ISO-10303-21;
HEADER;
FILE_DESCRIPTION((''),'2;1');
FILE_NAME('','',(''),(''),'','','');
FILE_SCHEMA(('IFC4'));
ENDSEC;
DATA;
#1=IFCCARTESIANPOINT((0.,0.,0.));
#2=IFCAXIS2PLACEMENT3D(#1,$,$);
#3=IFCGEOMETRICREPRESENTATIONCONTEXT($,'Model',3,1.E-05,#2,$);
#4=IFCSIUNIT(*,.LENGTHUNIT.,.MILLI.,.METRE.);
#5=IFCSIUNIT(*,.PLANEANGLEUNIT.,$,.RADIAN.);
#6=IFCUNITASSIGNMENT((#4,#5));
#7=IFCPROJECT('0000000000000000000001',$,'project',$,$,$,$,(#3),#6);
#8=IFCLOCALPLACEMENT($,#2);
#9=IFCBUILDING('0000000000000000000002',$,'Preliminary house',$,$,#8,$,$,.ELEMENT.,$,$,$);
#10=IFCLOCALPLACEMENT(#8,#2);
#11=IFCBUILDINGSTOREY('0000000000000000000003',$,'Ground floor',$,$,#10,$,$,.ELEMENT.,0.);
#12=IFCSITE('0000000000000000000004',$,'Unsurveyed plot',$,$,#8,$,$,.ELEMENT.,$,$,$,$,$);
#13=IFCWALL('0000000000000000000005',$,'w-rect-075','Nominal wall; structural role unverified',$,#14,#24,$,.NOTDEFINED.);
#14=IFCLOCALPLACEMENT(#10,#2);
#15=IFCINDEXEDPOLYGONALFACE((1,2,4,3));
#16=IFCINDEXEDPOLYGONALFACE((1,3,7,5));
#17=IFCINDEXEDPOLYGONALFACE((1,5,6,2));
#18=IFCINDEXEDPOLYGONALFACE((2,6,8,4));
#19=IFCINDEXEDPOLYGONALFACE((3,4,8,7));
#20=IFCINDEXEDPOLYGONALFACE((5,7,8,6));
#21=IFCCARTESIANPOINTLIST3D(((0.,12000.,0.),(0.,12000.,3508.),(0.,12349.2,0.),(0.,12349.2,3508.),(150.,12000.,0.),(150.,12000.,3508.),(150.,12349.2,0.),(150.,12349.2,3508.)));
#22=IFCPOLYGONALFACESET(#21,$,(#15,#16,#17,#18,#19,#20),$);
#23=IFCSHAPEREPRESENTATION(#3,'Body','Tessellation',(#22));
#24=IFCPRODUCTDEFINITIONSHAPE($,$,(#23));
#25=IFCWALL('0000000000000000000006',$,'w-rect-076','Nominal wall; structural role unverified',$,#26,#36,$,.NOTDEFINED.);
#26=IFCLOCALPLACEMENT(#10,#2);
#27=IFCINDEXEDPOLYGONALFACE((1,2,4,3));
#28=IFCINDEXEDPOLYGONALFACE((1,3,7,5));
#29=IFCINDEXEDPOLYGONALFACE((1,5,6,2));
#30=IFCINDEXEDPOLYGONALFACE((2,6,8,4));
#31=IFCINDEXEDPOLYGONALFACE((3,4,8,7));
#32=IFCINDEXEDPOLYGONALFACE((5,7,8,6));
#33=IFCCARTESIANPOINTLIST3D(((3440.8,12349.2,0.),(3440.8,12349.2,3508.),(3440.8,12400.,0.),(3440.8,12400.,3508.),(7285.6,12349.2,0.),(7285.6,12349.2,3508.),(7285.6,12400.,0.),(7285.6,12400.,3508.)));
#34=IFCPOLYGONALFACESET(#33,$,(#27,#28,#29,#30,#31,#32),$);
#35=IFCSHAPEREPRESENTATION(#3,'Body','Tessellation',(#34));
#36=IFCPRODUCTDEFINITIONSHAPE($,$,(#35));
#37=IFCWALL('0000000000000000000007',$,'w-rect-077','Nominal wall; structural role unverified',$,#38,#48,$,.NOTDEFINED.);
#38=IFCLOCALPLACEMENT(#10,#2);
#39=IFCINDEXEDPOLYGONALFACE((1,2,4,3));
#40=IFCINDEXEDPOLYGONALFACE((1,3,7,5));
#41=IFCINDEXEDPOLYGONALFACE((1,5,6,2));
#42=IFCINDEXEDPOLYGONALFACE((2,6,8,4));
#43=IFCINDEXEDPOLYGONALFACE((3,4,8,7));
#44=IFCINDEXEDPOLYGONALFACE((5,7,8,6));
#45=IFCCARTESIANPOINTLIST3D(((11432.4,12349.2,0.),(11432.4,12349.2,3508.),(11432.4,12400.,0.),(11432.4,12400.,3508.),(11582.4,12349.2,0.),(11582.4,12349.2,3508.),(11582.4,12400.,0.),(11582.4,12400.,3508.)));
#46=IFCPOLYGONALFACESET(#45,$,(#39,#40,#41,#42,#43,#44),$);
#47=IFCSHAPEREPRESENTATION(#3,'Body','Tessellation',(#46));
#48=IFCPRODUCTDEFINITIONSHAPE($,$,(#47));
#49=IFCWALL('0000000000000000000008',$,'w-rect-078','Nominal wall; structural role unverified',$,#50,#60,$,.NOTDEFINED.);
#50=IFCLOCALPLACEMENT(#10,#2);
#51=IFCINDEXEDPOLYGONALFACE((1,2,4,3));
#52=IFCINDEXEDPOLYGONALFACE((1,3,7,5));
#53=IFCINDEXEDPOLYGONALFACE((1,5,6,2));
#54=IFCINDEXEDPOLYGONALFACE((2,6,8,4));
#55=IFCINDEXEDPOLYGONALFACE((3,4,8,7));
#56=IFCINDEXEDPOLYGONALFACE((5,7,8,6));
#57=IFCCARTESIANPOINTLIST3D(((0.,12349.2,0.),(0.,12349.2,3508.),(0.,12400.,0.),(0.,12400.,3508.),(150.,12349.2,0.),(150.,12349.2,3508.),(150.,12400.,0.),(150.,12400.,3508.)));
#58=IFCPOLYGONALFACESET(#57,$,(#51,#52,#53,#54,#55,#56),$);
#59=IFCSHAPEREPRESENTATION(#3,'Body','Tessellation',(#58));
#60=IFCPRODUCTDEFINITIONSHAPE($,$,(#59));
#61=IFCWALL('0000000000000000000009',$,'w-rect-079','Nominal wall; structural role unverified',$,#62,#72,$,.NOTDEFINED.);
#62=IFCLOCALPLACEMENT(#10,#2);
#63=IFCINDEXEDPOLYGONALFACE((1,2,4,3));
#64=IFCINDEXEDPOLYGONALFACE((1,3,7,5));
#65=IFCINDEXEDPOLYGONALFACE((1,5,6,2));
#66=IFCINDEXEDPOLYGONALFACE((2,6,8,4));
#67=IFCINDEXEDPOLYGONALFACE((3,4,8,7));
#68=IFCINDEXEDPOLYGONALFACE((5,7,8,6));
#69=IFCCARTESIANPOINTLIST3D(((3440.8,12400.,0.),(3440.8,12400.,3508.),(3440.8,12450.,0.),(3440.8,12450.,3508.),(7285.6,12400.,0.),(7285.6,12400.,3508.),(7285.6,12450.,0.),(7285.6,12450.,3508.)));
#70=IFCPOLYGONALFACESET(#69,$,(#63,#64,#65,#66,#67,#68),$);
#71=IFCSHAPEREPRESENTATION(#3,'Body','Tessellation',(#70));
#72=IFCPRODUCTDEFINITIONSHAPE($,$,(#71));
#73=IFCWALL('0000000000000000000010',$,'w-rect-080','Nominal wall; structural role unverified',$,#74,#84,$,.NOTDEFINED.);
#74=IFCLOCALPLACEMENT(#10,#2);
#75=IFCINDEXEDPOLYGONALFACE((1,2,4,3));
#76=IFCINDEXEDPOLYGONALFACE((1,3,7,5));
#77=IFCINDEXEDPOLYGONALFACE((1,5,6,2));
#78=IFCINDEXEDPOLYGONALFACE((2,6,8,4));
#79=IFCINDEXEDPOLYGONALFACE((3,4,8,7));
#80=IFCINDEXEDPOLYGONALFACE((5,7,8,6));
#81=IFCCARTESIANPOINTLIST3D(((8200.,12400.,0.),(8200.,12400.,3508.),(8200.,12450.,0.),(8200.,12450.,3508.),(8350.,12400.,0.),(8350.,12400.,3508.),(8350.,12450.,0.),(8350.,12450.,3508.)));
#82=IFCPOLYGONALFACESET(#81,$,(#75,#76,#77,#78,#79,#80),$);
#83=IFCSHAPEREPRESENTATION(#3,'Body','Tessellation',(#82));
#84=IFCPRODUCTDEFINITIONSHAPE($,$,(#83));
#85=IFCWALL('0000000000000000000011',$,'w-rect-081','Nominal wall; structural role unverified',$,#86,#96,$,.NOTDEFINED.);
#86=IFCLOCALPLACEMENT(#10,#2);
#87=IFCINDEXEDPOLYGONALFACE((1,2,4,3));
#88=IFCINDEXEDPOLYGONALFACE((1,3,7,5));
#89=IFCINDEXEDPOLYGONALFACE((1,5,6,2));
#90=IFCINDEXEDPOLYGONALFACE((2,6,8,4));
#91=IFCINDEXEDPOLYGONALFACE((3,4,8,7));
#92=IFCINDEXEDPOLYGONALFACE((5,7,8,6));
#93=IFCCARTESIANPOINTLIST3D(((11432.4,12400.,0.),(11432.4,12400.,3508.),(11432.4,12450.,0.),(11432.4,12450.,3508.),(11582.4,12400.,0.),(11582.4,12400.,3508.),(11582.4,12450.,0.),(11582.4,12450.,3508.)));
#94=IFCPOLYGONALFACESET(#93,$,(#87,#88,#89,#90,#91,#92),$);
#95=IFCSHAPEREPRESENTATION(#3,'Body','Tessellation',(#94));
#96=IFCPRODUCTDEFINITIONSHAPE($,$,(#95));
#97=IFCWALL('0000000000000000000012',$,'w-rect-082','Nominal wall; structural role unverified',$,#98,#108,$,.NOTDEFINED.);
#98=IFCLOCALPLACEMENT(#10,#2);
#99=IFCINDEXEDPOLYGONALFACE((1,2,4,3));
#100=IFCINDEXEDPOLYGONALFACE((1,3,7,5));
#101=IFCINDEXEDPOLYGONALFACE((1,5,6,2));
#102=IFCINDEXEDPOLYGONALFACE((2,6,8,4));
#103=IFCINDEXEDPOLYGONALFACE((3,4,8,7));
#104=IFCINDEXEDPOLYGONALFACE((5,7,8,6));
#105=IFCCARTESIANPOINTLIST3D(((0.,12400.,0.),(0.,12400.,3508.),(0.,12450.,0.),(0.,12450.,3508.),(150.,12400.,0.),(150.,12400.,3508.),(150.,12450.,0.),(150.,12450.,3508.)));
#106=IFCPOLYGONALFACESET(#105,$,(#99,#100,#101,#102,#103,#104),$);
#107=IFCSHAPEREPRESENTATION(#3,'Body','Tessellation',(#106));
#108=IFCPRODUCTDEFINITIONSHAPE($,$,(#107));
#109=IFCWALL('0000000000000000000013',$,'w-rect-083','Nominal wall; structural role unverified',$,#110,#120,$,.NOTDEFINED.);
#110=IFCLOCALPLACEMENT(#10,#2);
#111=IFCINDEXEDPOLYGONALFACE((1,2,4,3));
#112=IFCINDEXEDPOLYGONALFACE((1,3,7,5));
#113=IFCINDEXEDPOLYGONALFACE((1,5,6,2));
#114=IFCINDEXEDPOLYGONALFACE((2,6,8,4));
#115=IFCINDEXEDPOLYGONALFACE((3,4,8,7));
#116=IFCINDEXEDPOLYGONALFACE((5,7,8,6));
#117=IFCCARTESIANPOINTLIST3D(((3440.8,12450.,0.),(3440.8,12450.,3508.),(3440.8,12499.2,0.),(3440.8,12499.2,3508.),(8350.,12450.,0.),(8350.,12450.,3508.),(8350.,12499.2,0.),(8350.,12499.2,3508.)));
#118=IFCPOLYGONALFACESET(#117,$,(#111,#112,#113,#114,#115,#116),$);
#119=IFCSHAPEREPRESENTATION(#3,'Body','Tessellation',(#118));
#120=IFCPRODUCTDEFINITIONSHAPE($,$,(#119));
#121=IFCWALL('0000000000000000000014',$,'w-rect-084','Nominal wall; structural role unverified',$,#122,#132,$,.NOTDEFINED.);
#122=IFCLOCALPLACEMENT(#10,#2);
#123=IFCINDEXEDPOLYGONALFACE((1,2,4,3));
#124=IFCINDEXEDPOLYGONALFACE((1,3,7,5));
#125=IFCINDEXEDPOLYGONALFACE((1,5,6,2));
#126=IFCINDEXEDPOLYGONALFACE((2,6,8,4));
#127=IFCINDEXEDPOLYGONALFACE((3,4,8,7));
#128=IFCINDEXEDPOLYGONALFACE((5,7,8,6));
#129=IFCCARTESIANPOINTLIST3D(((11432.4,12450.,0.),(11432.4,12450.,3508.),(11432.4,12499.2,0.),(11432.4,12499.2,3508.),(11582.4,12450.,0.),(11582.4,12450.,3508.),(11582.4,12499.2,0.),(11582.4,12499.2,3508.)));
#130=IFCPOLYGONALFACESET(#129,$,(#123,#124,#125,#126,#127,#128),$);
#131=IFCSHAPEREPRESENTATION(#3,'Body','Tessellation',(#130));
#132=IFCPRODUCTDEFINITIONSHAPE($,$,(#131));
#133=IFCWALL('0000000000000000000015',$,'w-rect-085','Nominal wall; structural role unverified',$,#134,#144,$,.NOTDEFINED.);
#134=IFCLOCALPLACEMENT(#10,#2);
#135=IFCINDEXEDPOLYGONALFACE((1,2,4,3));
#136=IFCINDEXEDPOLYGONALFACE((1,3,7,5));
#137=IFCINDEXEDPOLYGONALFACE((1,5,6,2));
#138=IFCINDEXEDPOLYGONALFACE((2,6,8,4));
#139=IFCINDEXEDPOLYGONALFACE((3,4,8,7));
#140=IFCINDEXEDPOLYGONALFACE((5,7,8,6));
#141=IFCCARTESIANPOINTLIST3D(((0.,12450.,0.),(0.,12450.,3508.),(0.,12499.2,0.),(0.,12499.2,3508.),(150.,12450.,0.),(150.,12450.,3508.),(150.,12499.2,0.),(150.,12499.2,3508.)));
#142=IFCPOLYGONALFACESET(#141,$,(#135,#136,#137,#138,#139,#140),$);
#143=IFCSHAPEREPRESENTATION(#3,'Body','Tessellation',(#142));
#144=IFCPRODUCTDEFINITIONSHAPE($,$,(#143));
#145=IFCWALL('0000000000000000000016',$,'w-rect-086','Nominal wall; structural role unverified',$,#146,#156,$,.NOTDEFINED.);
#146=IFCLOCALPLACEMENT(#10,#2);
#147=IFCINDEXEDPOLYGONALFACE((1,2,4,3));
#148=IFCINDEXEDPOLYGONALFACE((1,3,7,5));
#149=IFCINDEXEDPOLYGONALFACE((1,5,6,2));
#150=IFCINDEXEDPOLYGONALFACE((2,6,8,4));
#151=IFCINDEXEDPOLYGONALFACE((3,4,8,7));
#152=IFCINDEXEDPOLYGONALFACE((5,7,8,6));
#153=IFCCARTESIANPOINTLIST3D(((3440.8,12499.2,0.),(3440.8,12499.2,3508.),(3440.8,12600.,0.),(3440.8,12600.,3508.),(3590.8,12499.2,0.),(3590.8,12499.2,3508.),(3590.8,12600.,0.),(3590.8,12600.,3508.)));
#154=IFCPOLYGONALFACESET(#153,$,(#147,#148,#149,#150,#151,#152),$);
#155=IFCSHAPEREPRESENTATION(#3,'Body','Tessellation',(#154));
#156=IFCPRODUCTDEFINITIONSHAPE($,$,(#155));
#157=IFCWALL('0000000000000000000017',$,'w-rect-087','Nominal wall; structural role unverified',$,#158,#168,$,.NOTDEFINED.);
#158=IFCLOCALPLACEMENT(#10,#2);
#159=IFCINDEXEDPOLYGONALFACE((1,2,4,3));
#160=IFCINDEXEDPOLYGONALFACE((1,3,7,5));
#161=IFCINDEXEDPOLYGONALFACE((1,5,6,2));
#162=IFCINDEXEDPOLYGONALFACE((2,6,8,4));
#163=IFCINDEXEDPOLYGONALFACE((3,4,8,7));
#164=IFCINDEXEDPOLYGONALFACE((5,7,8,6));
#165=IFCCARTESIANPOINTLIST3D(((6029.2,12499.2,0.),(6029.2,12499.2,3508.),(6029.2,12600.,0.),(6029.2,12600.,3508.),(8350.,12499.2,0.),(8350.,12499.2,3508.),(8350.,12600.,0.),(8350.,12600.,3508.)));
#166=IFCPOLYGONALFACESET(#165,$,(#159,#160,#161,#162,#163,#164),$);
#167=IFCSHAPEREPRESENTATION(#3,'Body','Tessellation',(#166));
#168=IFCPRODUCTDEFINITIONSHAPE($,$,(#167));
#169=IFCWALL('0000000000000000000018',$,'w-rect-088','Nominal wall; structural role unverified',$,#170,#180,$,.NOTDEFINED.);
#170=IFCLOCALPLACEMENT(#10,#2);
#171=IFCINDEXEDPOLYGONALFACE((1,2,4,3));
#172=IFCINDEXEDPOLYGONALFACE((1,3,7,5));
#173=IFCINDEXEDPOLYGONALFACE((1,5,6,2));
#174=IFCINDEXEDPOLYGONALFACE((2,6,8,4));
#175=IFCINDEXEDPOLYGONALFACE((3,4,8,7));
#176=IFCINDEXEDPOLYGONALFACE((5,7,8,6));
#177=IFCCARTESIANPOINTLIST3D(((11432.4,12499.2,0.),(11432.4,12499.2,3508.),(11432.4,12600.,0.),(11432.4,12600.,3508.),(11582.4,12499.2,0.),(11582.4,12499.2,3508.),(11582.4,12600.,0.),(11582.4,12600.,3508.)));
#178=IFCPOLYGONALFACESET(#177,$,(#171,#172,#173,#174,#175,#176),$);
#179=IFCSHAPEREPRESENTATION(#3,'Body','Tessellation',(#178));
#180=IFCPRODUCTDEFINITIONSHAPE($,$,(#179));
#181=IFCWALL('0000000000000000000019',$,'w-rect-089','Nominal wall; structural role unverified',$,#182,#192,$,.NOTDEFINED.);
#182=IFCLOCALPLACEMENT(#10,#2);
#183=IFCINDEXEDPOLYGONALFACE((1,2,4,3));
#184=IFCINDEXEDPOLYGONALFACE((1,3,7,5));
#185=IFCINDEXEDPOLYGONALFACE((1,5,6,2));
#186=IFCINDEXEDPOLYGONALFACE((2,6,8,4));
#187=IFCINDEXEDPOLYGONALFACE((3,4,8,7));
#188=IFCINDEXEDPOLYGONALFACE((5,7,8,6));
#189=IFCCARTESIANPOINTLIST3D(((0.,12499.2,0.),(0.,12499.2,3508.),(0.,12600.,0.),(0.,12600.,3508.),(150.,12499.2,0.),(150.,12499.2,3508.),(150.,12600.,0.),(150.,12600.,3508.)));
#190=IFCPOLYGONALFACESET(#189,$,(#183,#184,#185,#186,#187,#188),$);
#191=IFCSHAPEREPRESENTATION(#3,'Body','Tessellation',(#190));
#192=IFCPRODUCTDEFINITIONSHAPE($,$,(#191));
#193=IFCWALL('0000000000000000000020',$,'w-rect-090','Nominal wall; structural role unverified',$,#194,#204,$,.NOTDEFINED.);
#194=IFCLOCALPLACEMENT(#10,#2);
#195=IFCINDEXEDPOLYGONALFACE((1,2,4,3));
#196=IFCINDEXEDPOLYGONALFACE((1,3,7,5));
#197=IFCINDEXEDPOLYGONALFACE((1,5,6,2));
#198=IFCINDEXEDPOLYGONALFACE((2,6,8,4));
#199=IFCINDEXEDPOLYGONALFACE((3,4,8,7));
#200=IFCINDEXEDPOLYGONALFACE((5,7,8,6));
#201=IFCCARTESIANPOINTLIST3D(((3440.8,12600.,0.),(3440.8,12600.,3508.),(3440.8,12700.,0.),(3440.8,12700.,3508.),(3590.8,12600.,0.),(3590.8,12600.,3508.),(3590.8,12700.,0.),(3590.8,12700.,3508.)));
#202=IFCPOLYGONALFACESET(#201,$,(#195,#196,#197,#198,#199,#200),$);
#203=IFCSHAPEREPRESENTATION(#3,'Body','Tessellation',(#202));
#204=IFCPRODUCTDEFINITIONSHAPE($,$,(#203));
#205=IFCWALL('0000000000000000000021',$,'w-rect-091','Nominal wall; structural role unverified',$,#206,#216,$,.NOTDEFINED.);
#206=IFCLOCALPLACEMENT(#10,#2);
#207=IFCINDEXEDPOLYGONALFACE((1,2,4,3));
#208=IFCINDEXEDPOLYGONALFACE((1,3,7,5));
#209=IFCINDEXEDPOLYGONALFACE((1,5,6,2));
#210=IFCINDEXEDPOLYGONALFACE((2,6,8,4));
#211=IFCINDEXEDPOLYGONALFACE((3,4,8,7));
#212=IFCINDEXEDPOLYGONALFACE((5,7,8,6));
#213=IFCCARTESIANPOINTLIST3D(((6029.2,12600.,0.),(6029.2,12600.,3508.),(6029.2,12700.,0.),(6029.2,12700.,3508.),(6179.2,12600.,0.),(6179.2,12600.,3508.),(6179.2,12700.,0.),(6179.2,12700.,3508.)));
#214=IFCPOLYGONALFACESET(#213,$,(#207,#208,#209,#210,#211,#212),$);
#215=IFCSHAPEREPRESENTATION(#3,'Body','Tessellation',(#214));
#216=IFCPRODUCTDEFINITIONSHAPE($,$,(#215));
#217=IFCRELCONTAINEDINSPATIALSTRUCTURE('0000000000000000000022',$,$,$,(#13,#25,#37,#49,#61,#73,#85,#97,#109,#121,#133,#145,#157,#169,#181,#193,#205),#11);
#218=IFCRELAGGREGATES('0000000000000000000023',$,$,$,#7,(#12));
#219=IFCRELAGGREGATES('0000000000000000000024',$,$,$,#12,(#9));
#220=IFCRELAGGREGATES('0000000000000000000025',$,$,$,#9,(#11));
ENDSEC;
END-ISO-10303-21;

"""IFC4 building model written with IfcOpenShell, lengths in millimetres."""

from ifc_helpers import new_model, si_unit, origin, place, context, project, spatial, polyline, outline, extrude, element, save


model = new_model("IFC4")

# Units and contexts
model_context = context("Model", 3, precision=1e-05, world=origin())
ifc_project = project(units=[si_unit("LENGTHUNIT", "METRE", prefix="MILLI"), si_unit("PLANEANGLEUNIT", "RADIAN")], contexts=[model_context])

# Site, building, storey
placement_1 = place(None, origin())
site = spatial("IfcSite", under=ifc_project, at=placement_1, Name="Unsurveyed plot", CompositionType="ELEMENT")
building = spatial("IfcBuilding", under=site, at=placement_1, Name="Preliminary house", CompositionType="ELEMENT")
placement_2 = place(placement_1, origin())
storey = spatial("IfcBuildingStorey", under=building, at=placement_2, Name="Ground floor", CompositionType="ELEMENT", Elevation=0.0)

# Walls
element("IfcWall", 1, at=placement_2, inside=storey, Name="w-rect-075", Description="Nominal wall; structural role unverified", PredefinedType="NOTDEFINED", context=model_context, shape_type="SweptSolid", body=[
    extrude(outline(polyline([(0.0, 12000.0), (150.0, 12000.0), (150.0, 12349.2), (0.0, 12349.2), (0.0, 12000.0)])), origin(), (0.0, 0.0, 1.0), 3508.0),
])
element("IfcWall", 2, at=placement_2, inside=storey, Name="w-rect-076", Description="Nominal wall; structural role unverified", PredefinedType="NOTDEFINED", context=model_context, shape_type="SweptSolid", body=[
    extrude(outline(polyline([(3440.8, 12349.2), (7285.6, 12349.2), (7285.6, 12400.0), (3440.8, 12400.0), (3440.8, 12349.2)])), origin(), (0.0, 0.0, 1.0), 3508.0),
])
element("IfcWall", 3, at=placement_2, inside=storey, Name="w-rect-077", Description="Nominal wall; structural role unverified", PredefinedType="NOTDEFINED", context=model_context, shape_type="SweptSolid", body=[
    extrude(outline(polyline([(11432.4, 12349.2), (11582.4, 12349.2), (11582.4, 12400.0), (11432.4, 12400.0), (11432.4, 12349.2)])), origin(), (0.0, 0.0, 1.0), 3508.0),
])
element("IfcWall", 4, at=placement_2, inside=storey, Name="w-rect-078", Description="Nominal wall; structural role unverified", PredefinedType="NOTDEFINED", context=model_context, shape_type="SweptSolid", body=[
    extrude(outline(polyline([(0.0, 12349.2), (150.0, 12349.2), (150.0, 12400.0), (0.0, 12400.0), (0.0, 12349.2)])), origin(), (0.0, 0.0, 1.0), 3508.0),
])
element("IfcWall", 5, at=placement_2, inside=storey, Name="w-rect-079", Description="Nominal wall; structural role unverified", PredefinedType="NOTDEFINED", context=model_context, shape_type="SweptSolid", body=[
    extrude(outline(polyline([(3440.8, 12400.0), (7285.6, 12400.0), (7285.6, 12450.0), (3440.8, 12450.0), (3440.8, 12400.0)])), origin(), (0.0, 0.0, 1.0), 3508.0),
])
element("IfcWall", 6, at=placement_2, inside=storey, Name="w-rect-080", Description="Nominal wall; structural role unverified", PredefinedType="NOTDEFINED", context=model_context, shape_type="SweptSolid", body=[
    extrude(outline(polyline([(8200.0, 12400.0), (8350.0, 12400.0), (8350.0, 12450.0), (8200.0, 12450.0), (8200.0, 12400.0)])), origin(), (0.0, 0.0, 1.0), 3508.0),
])
element("IfcWall", 7, at=placement_2, inside=storey, Name="w-rect-081", Description="Nominal wall; structural role unverified", PredefinedType="NOTDEFINED", context=model_context, shape_type="SweptSolid", body=[
    extrude(outline(polyline([(11432.4, 12400.0), (11582.4, 12400.0), (11582.4, 12450.0), (11432.4, 12450.0), (11432.4, 12400.0)])), origin(), (0.0, 0.0, 1.0), 3508.0),
])
element("IfcWall", 8, at=placement_2, inside=storey, Name="w-rect-082", Description="Nominal wall; structural role unverified", PredefinedType="NOTDEFINED", context=model_context, shape_type="SweptSolid", body=[
    extrude(outline(polyline([(0.0, 12400.0), (150.0, 12400.0), (150.0, 12450.0), (0.0, 12450.0), (0.0, 12400.0)])), origin(), (0.0, 0.0, 1.0), 3508.0),
])
element("IfcWall", 9, at=placement_2, inside=storey, Name="w-rect-083", Description="Nominal wall; structural role unverified", PredefinedType="NOTDEFINED", context=model_context, shape_type="SweptSolid", body=[
    extrude(outline(polyline([(3440.8, 12450.0), (8350.0, 12450.0), (8350.0, 12499.2), (3440.8, 12499.2), (3440.8, 12450.0)])), origin(), (0.0, 0.0, 1.0), 3508.0),
])
element("IfcWall", 10, at=placement_2, inside=storey, Name="w-rect-084", Description="Nominal wall; structural role unverified", PredefinedType="NOTDEFINED", context=model_context, shape_type="SweptSolid", body=[
    extrude(outline(polyline([(11432.4, 12450.0), (11582.4, 12450.0), (11582.4, 12499.2), (11432.4, 12499.2), (11432.4, 12450.0)])), origin(), (0.0, 0.0, 1.0), 3508.0),
])
element("IfcWall", 11, at=placement_2, inside=storey, Name="w-rect-085", Description="Nominal wall; structural role unverified", PredefinedType="NOTDEFINED", context=model_context, shape_type="SweptSolid", body=[
    extrude(outline(polyline([(0.0, 12450.0), (150.0, 12450.0), (150.0, 12499.2), (0.0, 12499.2), (0.0, 12450.0)])), origin(), (0.0, 0.0, 1.0), 3508.0),
])
element("IfcWall", 12, at=placement_2, inside=storey, Name="w-rect-086", Description="Nominal wall; structural role unverified", PredefinedType="NOTDEFINED", context=model_context, shape_type="SweptSolid", body=[
    extrude(outline(polyline([(3440.8, 12499.2), (3590.8, 12499.2), (3590.8, 12600.0), (3440.8, 12600.0), (3440.8, 12499.2)])), origin(), (0.0, 0.0, 1.0), 3508.0),
])
element("IfcWall", 13, at=placement_2, inside=storey, Name="w-rect-087", Description="Nominal wall; structural role unverified", PredefinedType="NOTDEFINED", context=model_context, shape_type="SweptSolid", body=[
    extrude(outline(polyline([(6029.2, 12499.2), (8350.0, 12499.2), (8350.0, 12600.0), (6029.2, 12600.0), (6029.2, 12499.2)])), origin(), (0.0, 0.0, 1.0), 3508.0),
])
element("IfcWall", 14, at=placement_2, inside=storey, Name="w-rect-088", Description="Nominal wall; structural role unverified", PredefinedType="NOTDEFINED", context=model_context, shape_type="SweptSolid", body=[
    extrude(outline(polyline([(11432.4, 12499.2), (11582.4, 12499.2), (11582.4, 12600.0), (11432.4, 12600.0), (11432.4, 12499.2)])), origin(), (0.0, 0.0, 1.0), 3508.0),
])
element("IfcWall", 15, at=placement_2, inside=storey, Name="w-rect-089", Description="Nominal wall; structural role unverified", PredefinedType="NOTDEFINED", context=model_context, shape_type="SweptSolid", body=[
    extrude(outline(polyline([(0.0, 12499.2), (150.0, 12499.2), (150.0, 12600.0), (0.0, 12600.0), (0.0, 12499.2)])), origin(), (0.0, 0.0, 1.0), 3508.0),
])
element("IfcWall", 16, at=placement_2, inside=storey, Name="w-rect-090", Description="Nominal wall; structural role unverified", PredefinedType="NOTDEFINED", context=model_context, shape_type="SweptSolid", body=[
    extrude(outline(polyline([(3440.8, 12600.0), (3590.8, 12600.0), (3590.8, 12700.0), (3440.8, 12700.0), (3440.8, 12600.0)])), origin(), (0.0, 0.0, 1.0), 3508.0),
])
element("IfcWall", 17, at=placement_2, inside=storey, Name="w-rect-091", Description="Nominal wall; structural role unverified", PredefinedType="NOTDEFINED", context=model_context, shape_type="SweptSolid", body=[
    extrude(outline(polyline([(6029.2, 12600.0), (6179.2, 12600.0), (6179.2, 12700.0), (6029.2, 12700.0), (6029.2, 12600.0)])), origin(), (0.0, 0.0, 1.0), 3508.0),
])

save(model, "model.ifc")
